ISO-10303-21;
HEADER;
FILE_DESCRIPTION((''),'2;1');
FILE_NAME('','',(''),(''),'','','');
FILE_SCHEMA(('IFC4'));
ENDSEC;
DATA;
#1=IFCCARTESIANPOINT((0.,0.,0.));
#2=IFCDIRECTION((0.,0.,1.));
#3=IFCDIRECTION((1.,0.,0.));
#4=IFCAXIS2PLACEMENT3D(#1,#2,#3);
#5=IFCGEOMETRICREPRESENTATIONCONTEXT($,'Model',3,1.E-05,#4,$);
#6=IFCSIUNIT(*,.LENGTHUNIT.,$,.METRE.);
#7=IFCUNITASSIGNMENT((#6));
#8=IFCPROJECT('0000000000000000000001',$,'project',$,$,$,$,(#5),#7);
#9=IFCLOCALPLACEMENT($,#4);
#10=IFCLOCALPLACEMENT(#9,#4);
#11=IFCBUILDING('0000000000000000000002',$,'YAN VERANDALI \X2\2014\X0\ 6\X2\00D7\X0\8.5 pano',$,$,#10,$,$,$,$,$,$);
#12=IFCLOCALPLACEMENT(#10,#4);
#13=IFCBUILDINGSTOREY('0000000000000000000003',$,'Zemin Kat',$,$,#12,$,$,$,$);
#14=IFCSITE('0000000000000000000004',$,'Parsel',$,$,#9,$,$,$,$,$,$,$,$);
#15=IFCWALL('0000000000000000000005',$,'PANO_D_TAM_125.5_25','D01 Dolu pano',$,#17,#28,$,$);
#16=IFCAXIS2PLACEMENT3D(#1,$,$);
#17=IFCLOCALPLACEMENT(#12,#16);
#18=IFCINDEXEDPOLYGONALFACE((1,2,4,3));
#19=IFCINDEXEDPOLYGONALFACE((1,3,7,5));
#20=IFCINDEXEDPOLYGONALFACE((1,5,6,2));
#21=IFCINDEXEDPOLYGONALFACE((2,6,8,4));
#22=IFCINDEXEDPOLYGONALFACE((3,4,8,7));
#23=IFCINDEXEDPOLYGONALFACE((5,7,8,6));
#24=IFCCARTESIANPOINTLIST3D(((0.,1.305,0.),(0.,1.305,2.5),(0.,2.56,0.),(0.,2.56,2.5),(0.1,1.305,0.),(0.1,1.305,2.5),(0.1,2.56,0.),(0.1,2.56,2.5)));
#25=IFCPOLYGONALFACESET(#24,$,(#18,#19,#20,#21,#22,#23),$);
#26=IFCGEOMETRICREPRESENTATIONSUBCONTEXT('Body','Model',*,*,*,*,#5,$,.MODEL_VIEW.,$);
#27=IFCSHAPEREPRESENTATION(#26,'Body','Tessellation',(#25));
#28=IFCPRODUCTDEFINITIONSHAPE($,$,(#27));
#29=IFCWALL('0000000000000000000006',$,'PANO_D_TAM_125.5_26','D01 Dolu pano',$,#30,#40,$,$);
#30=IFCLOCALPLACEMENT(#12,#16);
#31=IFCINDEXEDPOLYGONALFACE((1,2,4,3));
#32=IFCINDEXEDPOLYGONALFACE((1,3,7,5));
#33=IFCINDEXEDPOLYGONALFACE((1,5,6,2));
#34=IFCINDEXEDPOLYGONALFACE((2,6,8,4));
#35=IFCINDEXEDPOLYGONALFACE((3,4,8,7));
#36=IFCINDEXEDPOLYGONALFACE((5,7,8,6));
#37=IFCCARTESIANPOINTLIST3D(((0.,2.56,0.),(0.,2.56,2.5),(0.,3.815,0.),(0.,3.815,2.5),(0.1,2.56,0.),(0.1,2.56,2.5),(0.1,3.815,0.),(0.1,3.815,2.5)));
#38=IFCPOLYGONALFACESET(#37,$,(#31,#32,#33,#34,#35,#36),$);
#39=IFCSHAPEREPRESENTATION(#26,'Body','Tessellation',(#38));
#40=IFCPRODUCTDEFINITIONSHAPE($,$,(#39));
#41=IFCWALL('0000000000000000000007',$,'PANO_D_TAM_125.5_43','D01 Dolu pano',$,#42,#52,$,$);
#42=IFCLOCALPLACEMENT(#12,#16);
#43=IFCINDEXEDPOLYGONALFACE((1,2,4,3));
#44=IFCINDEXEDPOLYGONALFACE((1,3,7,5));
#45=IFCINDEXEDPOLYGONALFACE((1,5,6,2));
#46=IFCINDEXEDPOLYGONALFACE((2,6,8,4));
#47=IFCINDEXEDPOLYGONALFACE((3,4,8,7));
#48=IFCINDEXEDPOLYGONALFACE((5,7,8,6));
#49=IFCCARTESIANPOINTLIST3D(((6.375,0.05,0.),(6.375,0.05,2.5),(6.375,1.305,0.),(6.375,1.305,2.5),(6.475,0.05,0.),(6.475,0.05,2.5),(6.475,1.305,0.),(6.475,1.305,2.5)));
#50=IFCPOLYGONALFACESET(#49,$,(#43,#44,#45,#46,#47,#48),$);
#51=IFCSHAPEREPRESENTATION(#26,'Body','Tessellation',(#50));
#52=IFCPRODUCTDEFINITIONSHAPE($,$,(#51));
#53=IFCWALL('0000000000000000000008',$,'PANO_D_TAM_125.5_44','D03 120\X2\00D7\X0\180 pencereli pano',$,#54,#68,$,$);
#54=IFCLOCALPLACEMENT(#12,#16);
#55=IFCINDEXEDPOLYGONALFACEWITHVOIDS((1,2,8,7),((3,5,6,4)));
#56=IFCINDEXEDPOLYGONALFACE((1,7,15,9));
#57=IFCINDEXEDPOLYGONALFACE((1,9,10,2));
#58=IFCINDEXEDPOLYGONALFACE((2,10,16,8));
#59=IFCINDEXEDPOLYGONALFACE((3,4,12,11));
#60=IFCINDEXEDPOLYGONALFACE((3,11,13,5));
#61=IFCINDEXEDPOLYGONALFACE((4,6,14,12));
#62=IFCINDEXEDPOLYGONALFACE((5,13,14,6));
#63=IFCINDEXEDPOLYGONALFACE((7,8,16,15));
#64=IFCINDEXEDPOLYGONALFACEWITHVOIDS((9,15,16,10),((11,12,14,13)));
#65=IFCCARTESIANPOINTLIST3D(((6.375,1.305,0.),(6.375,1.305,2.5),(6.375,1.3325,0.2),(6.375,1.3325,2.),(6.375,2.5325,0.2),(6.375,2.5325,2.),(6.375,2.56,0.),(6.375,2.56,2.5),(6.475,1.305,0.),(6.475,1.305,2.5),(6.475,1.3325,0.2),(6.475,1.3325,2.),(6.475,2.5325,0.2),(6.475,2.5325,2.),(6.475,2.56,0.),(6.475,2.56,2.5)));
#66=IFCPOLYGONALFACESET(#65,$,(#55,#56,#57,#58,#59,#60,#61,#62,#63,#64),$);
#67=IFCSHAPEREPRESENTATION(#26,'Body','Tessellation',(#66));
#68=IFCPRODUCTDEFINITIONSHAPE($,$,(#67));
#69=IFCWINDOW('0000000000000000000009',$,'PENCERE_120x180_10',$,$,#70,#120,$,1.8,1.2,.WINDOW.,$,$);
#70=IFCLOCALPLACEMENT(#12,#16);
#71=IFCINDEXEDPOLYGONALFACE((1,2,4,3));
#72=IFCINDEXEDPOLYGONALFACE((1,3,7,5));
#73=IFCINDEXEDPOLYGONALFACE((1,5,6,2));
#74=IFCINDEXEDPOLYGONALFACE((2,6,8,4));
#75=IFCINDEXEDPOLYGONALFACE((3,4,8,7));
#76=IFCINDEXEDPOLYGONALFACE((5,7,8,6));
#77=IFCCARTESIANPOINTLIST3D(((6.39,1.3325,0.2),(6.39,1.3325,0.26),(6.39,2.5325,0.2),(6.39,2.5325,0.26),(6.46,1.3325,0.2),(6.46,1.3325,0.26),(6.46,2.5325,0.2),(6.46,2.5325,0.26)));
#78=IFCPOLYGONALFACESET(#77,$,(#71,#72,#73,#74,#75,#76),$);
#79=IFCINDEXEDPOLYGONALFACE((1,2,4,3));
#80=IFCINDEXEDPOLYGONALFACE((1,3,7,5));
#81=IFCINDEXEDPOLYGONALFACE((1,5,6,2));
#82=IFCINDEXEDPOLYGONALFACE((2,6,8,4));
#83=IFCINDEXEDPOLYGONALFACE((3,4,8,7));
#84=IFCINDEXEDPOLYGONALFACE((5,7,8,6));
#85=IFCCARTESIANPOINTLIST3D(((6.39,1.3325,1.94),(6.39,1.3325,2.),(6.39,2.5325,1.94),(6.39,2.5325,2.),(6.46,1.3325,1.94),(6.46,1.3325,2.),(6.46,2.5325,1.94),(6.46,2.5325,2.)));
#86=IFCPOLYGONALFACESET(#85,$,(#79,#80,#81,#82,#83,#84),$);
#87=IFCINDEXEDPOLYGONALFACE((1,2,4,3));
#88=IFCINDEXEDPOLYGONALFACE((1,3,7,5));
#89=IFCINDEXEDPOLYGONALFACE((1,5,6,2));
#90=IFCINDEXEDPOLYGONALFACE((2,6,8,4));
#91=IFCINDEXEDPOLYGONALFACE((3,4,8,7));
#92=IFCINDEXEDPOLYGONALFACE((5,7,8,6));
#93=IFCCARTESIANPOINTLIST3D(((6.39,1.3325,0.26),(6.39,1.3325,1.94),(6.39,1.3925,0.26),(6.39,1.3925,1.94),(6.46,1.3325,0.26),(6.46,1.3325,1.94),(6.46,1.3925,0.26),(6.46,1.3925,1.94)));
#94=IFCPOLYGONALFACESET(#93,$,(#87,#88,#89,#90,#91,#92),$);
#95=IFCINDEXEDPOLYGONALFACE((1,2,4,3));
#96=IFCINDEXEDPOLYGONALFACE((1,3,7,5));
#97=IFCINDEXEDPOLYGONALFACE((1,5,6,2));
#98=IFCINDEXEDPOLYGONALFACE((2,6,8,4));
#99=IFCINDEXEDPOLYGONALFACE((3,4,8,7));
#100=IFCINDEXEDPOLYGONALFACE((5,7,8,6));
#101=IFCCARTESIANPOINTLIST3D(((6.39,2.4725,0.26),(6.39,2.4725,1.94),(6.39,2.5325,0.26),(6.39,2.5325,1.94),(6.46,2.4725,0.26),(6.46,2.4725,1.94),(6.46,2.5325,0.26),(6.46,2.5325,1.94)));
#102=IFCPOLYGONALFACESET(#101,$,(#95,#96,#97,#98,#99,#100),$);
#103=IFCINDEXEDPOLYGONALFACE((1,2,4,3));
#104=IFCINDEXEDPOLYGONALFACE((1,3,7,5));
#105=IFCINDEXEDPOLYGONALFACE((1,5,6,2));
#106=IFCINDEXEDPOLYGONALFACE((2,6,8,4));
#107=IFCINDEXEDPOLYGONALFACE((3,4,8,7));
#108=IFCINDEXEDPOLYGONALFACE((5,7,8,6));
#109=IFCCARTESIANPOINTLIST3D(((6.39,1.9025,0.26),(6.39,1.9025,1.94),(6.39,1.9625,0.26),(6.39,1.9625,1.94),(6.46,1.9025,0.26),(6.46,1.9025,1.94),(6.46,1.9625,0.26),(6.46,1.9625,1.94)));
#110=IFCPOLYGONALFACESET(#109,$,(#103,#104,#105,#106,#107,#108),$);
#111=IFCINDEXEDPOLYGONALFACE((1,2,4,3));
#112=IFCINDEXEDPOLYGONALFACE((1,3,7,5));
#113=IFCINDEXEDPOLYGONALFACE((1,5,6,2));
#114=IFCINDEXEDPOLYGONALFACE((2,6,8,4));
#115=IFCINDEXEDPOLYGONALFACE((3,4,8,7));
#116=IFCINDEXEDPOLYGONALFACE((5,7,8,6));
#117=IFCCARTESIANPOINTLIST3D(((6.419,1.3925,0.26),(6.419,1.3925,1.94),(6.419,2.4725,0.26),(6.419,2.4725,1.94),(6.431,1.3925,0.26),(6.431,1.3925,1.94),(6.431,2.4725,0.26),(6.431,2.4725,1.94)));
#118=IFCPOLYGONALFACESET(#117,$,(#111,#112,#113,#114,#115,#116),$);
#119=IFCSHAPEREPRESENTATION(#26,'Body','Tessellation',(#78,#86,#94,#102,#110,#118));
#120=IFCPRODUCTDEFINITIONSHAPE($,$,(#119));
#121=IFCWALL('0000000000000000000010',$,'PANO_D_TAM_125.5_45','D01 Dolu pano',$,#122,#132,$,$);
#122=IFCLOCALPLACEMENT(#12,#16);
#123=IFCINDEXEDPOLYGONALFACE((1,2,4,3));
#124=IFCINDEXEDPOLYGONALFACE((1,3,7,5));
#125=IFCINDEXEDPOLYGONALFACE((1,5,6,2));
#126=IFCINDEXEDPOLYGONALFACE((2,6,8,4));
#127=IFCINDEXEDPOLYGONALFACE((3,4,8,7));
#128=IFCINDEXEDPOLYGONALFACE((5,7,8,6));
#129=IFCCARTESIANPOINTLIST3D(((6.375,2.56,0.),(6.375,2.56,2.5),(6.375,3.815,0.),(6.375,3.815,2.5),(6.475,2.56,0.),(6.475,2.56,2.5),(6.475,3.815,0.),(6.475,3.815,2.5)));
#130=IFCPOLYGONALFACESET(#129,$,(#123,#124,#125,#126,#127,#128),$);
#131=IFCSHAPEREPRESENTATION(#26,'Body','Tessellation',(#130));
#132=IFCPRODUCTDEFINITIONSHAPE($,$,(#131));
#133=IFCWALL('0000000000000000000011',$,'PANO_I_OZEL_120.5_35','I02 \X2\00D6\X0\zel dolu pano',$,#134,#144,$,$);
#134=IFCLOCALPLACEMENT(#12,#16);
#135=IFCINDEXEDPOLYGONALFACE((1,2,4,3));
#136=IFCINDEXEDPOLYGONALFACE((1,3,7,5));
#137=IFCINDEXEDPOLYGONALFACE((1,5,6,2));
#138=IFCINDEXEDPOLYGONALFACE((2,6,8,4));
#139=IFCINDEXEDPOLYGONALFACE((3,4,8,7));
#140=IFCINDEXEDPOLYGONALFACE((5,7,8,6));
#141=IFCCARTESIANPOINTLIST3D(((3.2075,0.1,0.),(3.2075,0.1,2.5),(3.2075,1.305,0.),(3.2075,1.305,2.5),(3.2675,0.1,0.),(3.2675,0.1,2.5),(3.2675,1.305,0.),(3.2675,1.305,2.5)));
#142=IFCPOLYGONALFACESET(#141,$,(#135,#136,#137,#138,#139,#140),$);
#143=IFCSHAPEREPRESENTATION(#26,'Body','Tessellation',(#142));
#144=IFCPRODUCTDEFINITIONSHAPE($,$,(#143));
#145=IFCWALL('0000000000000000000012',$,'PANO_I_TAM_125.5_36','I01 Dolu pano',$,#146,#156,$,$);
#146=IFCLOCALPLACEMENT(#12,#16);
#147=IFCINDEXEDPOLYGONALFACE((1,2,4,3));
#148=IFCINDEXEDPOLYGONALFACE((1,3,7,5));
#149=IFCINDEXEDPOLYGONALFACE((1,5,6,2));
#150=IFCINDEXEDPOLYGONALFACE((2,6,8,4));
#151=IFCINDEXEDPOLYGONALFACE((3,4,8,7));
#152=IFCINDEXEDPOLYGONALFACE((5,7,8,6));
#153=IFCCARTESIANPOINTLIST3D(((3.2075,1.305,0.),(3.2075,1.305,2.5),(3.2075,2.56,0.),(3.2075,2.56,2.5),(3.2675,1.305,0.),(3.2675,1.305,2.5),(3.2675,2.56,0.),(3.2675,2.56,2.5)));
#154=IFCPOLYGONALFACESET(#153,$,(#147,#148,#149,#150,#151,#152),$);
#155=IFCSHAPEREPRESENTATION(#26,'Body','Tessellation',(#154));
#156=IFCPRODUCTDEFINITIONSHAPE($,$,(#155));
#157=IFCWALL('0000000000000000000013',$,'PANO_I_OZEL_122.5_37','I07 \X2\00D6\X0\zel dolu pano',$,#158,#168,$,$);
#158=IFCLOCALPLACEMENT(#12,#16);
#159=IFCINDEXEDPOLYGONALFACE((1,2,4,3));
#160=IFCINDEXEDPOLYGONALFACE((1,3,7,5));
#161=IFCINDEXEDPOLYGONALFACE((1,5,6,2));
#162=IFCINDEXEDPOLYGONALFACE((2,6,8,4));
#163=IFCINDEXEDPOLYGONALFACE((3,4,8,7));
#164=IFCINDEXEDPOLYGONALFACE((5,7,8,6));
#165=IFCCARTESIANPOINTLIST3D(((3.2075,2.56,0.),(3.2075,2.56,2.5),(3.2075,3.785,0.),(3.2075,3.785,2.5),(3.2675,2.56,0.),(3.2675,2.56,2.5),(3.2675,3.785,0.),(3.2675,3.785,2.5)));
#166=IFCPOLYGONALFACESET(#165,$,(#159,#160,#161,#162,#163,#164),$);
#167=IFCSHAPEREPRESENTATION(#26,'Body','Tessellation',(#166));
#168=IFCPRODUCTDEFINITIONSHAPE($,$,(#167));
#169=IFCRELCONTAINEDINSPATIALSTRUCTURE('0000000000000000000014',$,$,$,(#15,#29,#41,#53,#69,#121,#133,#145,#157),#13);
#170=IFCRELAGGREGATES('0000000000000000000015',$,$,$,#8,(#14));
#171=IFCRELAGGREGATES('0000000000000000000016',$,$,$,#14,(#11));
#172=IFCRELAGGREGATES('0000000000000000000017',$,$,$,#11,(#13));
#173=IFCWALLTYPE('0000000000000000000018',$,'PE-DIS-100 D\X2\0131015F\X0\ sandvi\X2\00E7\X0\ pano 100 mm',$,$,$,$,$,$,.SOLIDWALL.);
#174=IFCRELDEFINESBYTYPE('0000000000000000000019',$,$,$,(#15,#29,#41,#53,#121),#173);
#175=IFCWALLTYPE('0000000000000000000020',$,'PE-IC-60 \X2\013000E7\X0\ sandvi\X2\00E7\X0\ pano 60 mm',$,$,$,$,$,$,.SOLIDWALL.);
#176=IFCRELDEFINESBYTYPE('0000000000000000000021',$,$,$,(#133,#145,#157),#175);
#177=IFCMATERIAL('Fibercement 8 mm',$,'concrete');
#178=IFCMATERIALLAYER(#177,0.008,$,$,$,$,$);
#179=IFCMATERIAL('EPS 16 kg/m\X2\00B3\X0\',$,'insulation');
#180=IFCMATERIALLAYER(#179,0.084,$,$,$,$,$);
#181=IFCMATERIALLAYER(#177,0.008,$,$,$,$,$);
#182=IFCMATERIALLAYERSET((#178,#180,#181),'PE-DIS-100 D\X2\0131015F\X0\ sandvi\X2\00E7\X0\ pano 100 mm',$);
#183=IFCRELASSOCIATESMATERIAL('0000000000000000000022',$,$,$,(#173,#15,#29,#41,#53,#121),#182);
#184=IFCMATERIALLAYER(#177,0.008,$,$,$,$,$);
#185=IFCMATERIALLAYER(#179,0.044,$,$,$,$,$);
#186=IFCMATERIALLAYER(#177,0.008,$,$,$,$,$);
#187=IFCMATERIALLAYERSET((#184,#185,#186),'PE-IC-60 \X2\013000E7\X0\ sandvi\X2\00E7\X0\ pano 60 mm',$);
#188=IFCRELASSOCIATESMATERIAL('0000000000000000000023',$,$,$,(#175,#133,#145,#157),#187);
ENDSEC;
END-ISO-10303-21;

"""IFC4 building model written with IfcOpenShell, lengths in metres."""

from ifc_helpers import new_model, si_unit, frame, origin_with_axes, place, context, subcontext, project, spatial, line, indexed_curve, outline, extrude, material, layer, layer_set, layer_usage, type_object, element, fill, save


model = new_model("IFC4")

# Units and contexts
model_context = context("Model", 3, precision=1e-05, world=origin_with_axes())
body_context = subcontext(model_context, "Body", "Model", "MODEL_VIEW")
ifc_project = project(units=[si_unit("LENGTHUNIT", "METRE")], contexts=[model_context])

# Site, building, storey
site_placement = place(None, origin_with_axes())
site = spatial("IfcSite", under=ifc_project, at=site_placement, Name="Parsel")
building_placement = place(site_placement, origin_with_axes())
building = spatial("IfcBuilding", under=site, at=building_placement, Name="YAN VERANDALI — 6×8.5 pano")
storey_placement = place(building_placement, origin_with_axes())
storey = spatial("IfcBuildingStorey", under=building, at=storey_placement, Name="Zemin Kat")

# Walls
ifc_material_1 = material(Name="Fibercement 8 mm", Category="concrete")
ifc_layer_1 = layer(ifc_material_1, 0.008)
ifc_material_2 = material(Name="EPS 16 kg/m³", Category="insulation")
ifc_layer_2 = layer(ifc_material_2, 0.084)
ifc_layer_3 = layer(ifc_material_1, 0.008)
ifc_layer_set_1 = layer_set([ifc_layer_1, ifc_layer_2, ifc_layer_3], Name="PE-DIS-100 Dış sandviç pano 100 mm")
wall_type_1 = type_object("IfcWallType", Name="PE-DIS-100 Dış sandviç pano 100 mm", PredefinedType="SOLIDWALL", material=ifc_layer_set_1)
ifc_layer_usage_1 = layer_usage(ifc_layer_set_1, "AXIS2", "POSITIVE", 0.0)
wall_1_placement = place(storey_placement, frame((0.1, 1.305, 0.0), z_axis=(0.0, 0.0, 1.0), x_axis=(0.0, 1.0, 0.0)))
element("IfcWall", 1, at=wall_1_placement, inside=storey, type_object=wall_type_1, material=ifc_layer_usage_1, Name="PANO_D_TAM_125.5_25", Description="D01 Dolu pano", context=body_context, shape_type="SweptSolid", body=[
    extrude(outline(indexed_curve([(0.0, 0.0), (1.255, 0.0), (1.255, 0.1), (0.0, 0.1)], segments=[line(1, 2, 3, 4, 1)])), origin_with_axes(), (0.0, 0.0, 1.0), 2.5),
])
ifc_layer_usage_2 = layer_usage(ifc_layer_set_1, "AXIS2", "POSITIVE", 0.0)
wall_2_placement = place(storey_placement, frame((0.1, 2.56, 0.0), z_axis=(0.0, 0.0, 1.0), x_axis=(0.0, 1.0, 0.0)))
element("IfcWall", 2, at=wall_2_placement, inside=storey, type_object=wall_type_1, material=ifc_layer_usage_2, Name="PANO_D_TAM_125.5_26", Description="D01 Dolu pano", context=body_context, shape_type="SweptSolid", body=[
    extrude(outline(indexed_curve([(0.0, 0.0), (1.255, 0.0), (1.255, 0.1), (0.0, 0.1)], segments=[line(1, 2, 3, 4, 1)])), origin_with_axes(), (0.0, 0.0, 1.0), 2.5),
])
ifc_layer_usage_3 = layer_usage(ifc_layer_set_1, "AXIS2", "POSITIVE", 0.0)
wall_3_placement = place(storey_placement, frame((6.475, 0.05, 0.0), z_axis=(0.0, 0.0, 1.0), x_axis=(0.0, 1.0, 0.0)))
element("IfcWall", 3, at=wall_3_placement, inside=storey, type_object=wall_type_1, material=ifc_layer_usage_3, Name="PANO_D_TAM_125.5_43", Description="D01 Dolu pano", context=body_context, shape_type="SweptSolid", body=[
    extrude(outline(indexed_curve([(0.0, 0.0), (1.255, 0.0), (1.255, 0.1), (0.0, 0.1)], segments=[line(1, 2, 3, 4, 1)])), origin_with_axes(), (0.0, 0.0, 1.0), 2.5),
])

# Wall, opening, window
ifc_layer_usage_4 = layer_usage(ifc_layer_set_1, "AXIS2", "POSITIVE", 0.0)
wall_4_placement = place(storey_placement, frame((6.475, 1.305, 0.0), z_axis=(0.0, 0.0, 1.0), x_axis=(0.0, 1.0, 0.0)))
wall_4 = element("IfcWall", 4, at=wall_4_placement, inside=storey, type_object=wall_type_1, material=ifc_layer_usage_4, Name="PANO_D_TAM_125.5_44", Description="D03 120×180 pencereli pano", context=body_context, shape_type="SweptSolid", body=[
    extrude(outline(indexed_curve([(0.0, 0.0), (1.255, 0.0), (1.255, 0.1), (0.0, 0.1)], segments=[line(1, 2, 3, 4, 1)])), origin_with_axes(), (0.0, 0.0, 1.0), 2.5),
])
opening_placement = place(wall_4_placement, origin_with_axes())
opening = element("IfcOpeningElement", 5, at=opening_placement, cuts=wall_4, PredefinedType="OPENING", context=body_context, shape_type="SweptSolid", body=[
    extrude(outline(indexed_curve([(0.0, 0.0), (1.2, 0.0), (1.2, 0.14), (0.0, 0.14)], segments=[line(1, 2, 3, 4, 1)])), frame((0.0275, -0.02, 0.2), z_axis=(0.0, 0.0, 1.0), x_axis=(1.0, 0.0, 0.0)), (0.0, 0.0, 1.0), 1.8),
])
window_placement = place(storey_placement, frame((6.475, 1.305, 0.0), z_axis=(0.0, 0.0, 1.0), x_axis=(0.0, 1.0, 0.0)))
window = element("IfcWindow", 6, at=window_placement, inside=storey, Name="PENCERE_120x180_10", OverallHeight=1.8, OverallWidth=1.2, PredefinedType="WINDOW", context=body_context, shape_type="SweptSolid", body=[
    extrude(outline(indexed_curve([(0.0, 0.0), (1.2, 0.0), (1.2, 0.07), (0.0, 0.07)], segments=[line(1, 2, 3, 4, 1)])), frame((0.0275, 0.015, 0.2), z_axis=(0.0, 0.0, 1.0), x_axis=(1.0, 0.0, 0.0)), (0.0, 0.0, 1.0), 0.06),
    extrude(outline(indexed_curve([(0.0, 0.0), (1.2, 0.0), (1.2, 0.07), (0.0, 0.07)], segments=[line(1, 2, 3, 4, 1)])), frame((0.0275, 0.015, 1.94), z_axis=(0.0, 0.0, 1.0), x_axis=(1.0, 0.0, 0.0)), (0.0, 0.0, 1.0), 0.06),
    extrude(outline(indexed_curve([(0.0, 0.0), (0.06, 0.0), (0.06, 0.07), (0.0, 0.07)], segments=[line(1, 2, 3, 4, 1)])), frame((0.0275, 0.015, 0.26), z_axis=(0.0, 0.0, 1.0), x_axis=(1.0, 0.0, 0.0)), (0.0, 0.0, 1.0), 1.68),
    extrude(outline(indexed_curve([(0.0, 0.0), (0.06, 0.0), (0.06, 0.07), (0.0, 0.07)], segments=[line(1, 2, 3, 4, 1)])), frame((1.1675, 0.015, 0.26), z_axis=(0.0, 0.0, 1.0), x_axis=(1.0, 0.0, 0.0)), (0.0, 0.0, 1.0), 1.68),
    extrude(outline(indexed_curve([(0.0, 0.0), (0.06, 0.0), (0.06, 0.07), (0.0, 0.07)], segments=[line(1, 2, 3, 4, 1)])), frame((0.5975, 0.015, 0.26), z_axis=(0.0, 0.0, 1.0), x_axis=(1.0, 0.0, 0.0)), (0.0, 0.0, 1.0), 1.68),
    extrude(outline(indexed_curve([(0.0, 0.0), (1.08, 0.0), (1.08, 0.012), (0.0, 0.012)], segments=[line(1, 2, 3, 4, 1)])), frame((0.0875, 0.044, 0.26), z_axis=(0.0, 0.0, 1.0), x_axis=(1.0, 0.0, 0.0)), (0.0, 0.0, 1.0), 1.68),
])
fill(opening, window)

# Walls
ifc_layer_usage_5 = layer_usage(ifc_layer_set_1, "AXIS2", "POSITIVE", 0.0)
wall_5_placement = place(storey_placement, frame((6.475, 2.56, 0.0), z_axis=(0.0, 0.0, 1.0), x_axis=(0.0, 1.0, 0.0)))
element("IfcWall", 7, at=wall_5_placement, inside=storey, type_object=wall_type_1, material=ifc_layer_usage_5, Name="PANO_D_TAM_125.5_45", Description="D01 Dolu pano", context=body_context, shape_type="SweptSolid", body=[
    extrude(outline(indexed_curve([(0.0, 0.0), (1.255, 0.0), (1.255, 0.1), (0.0, 0.1)], segments=[line(1, 2, 3, 4, 1)])), origin_with_axes(), (0.0, 0.0, 1.0), 2.5),
])
ifc_layer_4 = layer(ifc_material_1, 0.008)
ifc_layer_5 = layer(ifc_material_2, 0.044)
ifc_layer_6 = layer(ifc_material_1, 0.008)
ifc_layer_set_2 = layer_set([ifc_layer_4, ifc_layer_5, ifc_layer_6], Name="PE-IC-60 İç sandviç pano 60 mm")
ifc_layer_usage_6 = layer_usage(ifc_layer_set_2, "AXIS2", "POSITIVE", 0.0)
wall_type_2 = type_object("IfcWallType", Name="PE-IC-60 İç sandviç pano 60 mm", PredefinedType="SOLIDWALL", material=ifc_layer_set_2)
wall_6_placement = place(storey_placement, frame((3.2675, 0.1, 0.0), z_axis=(0.0, 0.0, 1.0), x_axis=(0.0, 1.0, 0.0)))
element("IfcWall", 8, at=wall_6_placement, inside=storey, type_object=wall_type_2, material=ifc_layer_usage_6, Name="PANO_I_OZEL_120.5_35", Description="I02 Özel dolu pano", context=body_context, shape_type="SweptSolid", body=[
    extrude(outline(indexed_curve([(0.0, 0.0), (1.205, 0.0), (1.205, 0.06), (0.0, 0.06)], segments=[line(1, 2, 3, 4, 1)])), origin_with_axes(), (0.0, 0.0, 1.0), 2.5),
])
ifc_layer_usage_7 = layer_usage(ifc_layer_set_2, "AXIS2", "POSITIVE", 0.0)
wall_7_placement = place(storey_placement, frame((3.2675, 1.305, 0.0), z_axis=(0.0, 0.0, 1.0), x_axis=(0.0, 1.0, 0.0)))
element("IfcWall", 9, at=wall_7_placement, inside=storey, type_object=wall_type_2, material=ifc_layer_usage_7, Name="PANO_I_TAM_125.5_36", Description="I01 Dolu pano", context=body_context, shape_type="SweptSolid", body=[
    extrude(outline(indexed_curve([(0.0, 0.0), (1.255, 0.0), (1.255, 0.06), (0.0, 0.06)], segments=[line(1, 2, 3, 4, 1)])), origin_with_axes(), (0.0, 0.0, 1.0), 2.5),
])
ifc_layer_usage_8 = layer_usage(ifc_layer_set_2, "AXIS2", "POSITIVE", 0.0)
wall_8_placement = place(storey_placement, frame((3.2675, 2.56, 0.0), z_axis=(0.0, 0.0, 1.0), x_axis=(0.0, 1.0, 0.0)))
element("IfcWall", 10, at=wall_8_placement, inside=storey, type_object=wall_type_2, material=ifc_layer_usage_8, Name="PANO_I_OZEL_122.5_37", Description="I07 Özel dolu pano", context=body_context, shape_type="SweptSolid", body=[
    extrude(outline(indexed_curve([(0.0, 0.0), (1.225, 0.0), (1.225, 0.06), (0.0, 0.06)], segments=[line(1, 2, 3, 4, 1)])), origin_with_axes(), (0.0, 0.0, 1.0), 2.5),
])

save(model, "model.ifc")
